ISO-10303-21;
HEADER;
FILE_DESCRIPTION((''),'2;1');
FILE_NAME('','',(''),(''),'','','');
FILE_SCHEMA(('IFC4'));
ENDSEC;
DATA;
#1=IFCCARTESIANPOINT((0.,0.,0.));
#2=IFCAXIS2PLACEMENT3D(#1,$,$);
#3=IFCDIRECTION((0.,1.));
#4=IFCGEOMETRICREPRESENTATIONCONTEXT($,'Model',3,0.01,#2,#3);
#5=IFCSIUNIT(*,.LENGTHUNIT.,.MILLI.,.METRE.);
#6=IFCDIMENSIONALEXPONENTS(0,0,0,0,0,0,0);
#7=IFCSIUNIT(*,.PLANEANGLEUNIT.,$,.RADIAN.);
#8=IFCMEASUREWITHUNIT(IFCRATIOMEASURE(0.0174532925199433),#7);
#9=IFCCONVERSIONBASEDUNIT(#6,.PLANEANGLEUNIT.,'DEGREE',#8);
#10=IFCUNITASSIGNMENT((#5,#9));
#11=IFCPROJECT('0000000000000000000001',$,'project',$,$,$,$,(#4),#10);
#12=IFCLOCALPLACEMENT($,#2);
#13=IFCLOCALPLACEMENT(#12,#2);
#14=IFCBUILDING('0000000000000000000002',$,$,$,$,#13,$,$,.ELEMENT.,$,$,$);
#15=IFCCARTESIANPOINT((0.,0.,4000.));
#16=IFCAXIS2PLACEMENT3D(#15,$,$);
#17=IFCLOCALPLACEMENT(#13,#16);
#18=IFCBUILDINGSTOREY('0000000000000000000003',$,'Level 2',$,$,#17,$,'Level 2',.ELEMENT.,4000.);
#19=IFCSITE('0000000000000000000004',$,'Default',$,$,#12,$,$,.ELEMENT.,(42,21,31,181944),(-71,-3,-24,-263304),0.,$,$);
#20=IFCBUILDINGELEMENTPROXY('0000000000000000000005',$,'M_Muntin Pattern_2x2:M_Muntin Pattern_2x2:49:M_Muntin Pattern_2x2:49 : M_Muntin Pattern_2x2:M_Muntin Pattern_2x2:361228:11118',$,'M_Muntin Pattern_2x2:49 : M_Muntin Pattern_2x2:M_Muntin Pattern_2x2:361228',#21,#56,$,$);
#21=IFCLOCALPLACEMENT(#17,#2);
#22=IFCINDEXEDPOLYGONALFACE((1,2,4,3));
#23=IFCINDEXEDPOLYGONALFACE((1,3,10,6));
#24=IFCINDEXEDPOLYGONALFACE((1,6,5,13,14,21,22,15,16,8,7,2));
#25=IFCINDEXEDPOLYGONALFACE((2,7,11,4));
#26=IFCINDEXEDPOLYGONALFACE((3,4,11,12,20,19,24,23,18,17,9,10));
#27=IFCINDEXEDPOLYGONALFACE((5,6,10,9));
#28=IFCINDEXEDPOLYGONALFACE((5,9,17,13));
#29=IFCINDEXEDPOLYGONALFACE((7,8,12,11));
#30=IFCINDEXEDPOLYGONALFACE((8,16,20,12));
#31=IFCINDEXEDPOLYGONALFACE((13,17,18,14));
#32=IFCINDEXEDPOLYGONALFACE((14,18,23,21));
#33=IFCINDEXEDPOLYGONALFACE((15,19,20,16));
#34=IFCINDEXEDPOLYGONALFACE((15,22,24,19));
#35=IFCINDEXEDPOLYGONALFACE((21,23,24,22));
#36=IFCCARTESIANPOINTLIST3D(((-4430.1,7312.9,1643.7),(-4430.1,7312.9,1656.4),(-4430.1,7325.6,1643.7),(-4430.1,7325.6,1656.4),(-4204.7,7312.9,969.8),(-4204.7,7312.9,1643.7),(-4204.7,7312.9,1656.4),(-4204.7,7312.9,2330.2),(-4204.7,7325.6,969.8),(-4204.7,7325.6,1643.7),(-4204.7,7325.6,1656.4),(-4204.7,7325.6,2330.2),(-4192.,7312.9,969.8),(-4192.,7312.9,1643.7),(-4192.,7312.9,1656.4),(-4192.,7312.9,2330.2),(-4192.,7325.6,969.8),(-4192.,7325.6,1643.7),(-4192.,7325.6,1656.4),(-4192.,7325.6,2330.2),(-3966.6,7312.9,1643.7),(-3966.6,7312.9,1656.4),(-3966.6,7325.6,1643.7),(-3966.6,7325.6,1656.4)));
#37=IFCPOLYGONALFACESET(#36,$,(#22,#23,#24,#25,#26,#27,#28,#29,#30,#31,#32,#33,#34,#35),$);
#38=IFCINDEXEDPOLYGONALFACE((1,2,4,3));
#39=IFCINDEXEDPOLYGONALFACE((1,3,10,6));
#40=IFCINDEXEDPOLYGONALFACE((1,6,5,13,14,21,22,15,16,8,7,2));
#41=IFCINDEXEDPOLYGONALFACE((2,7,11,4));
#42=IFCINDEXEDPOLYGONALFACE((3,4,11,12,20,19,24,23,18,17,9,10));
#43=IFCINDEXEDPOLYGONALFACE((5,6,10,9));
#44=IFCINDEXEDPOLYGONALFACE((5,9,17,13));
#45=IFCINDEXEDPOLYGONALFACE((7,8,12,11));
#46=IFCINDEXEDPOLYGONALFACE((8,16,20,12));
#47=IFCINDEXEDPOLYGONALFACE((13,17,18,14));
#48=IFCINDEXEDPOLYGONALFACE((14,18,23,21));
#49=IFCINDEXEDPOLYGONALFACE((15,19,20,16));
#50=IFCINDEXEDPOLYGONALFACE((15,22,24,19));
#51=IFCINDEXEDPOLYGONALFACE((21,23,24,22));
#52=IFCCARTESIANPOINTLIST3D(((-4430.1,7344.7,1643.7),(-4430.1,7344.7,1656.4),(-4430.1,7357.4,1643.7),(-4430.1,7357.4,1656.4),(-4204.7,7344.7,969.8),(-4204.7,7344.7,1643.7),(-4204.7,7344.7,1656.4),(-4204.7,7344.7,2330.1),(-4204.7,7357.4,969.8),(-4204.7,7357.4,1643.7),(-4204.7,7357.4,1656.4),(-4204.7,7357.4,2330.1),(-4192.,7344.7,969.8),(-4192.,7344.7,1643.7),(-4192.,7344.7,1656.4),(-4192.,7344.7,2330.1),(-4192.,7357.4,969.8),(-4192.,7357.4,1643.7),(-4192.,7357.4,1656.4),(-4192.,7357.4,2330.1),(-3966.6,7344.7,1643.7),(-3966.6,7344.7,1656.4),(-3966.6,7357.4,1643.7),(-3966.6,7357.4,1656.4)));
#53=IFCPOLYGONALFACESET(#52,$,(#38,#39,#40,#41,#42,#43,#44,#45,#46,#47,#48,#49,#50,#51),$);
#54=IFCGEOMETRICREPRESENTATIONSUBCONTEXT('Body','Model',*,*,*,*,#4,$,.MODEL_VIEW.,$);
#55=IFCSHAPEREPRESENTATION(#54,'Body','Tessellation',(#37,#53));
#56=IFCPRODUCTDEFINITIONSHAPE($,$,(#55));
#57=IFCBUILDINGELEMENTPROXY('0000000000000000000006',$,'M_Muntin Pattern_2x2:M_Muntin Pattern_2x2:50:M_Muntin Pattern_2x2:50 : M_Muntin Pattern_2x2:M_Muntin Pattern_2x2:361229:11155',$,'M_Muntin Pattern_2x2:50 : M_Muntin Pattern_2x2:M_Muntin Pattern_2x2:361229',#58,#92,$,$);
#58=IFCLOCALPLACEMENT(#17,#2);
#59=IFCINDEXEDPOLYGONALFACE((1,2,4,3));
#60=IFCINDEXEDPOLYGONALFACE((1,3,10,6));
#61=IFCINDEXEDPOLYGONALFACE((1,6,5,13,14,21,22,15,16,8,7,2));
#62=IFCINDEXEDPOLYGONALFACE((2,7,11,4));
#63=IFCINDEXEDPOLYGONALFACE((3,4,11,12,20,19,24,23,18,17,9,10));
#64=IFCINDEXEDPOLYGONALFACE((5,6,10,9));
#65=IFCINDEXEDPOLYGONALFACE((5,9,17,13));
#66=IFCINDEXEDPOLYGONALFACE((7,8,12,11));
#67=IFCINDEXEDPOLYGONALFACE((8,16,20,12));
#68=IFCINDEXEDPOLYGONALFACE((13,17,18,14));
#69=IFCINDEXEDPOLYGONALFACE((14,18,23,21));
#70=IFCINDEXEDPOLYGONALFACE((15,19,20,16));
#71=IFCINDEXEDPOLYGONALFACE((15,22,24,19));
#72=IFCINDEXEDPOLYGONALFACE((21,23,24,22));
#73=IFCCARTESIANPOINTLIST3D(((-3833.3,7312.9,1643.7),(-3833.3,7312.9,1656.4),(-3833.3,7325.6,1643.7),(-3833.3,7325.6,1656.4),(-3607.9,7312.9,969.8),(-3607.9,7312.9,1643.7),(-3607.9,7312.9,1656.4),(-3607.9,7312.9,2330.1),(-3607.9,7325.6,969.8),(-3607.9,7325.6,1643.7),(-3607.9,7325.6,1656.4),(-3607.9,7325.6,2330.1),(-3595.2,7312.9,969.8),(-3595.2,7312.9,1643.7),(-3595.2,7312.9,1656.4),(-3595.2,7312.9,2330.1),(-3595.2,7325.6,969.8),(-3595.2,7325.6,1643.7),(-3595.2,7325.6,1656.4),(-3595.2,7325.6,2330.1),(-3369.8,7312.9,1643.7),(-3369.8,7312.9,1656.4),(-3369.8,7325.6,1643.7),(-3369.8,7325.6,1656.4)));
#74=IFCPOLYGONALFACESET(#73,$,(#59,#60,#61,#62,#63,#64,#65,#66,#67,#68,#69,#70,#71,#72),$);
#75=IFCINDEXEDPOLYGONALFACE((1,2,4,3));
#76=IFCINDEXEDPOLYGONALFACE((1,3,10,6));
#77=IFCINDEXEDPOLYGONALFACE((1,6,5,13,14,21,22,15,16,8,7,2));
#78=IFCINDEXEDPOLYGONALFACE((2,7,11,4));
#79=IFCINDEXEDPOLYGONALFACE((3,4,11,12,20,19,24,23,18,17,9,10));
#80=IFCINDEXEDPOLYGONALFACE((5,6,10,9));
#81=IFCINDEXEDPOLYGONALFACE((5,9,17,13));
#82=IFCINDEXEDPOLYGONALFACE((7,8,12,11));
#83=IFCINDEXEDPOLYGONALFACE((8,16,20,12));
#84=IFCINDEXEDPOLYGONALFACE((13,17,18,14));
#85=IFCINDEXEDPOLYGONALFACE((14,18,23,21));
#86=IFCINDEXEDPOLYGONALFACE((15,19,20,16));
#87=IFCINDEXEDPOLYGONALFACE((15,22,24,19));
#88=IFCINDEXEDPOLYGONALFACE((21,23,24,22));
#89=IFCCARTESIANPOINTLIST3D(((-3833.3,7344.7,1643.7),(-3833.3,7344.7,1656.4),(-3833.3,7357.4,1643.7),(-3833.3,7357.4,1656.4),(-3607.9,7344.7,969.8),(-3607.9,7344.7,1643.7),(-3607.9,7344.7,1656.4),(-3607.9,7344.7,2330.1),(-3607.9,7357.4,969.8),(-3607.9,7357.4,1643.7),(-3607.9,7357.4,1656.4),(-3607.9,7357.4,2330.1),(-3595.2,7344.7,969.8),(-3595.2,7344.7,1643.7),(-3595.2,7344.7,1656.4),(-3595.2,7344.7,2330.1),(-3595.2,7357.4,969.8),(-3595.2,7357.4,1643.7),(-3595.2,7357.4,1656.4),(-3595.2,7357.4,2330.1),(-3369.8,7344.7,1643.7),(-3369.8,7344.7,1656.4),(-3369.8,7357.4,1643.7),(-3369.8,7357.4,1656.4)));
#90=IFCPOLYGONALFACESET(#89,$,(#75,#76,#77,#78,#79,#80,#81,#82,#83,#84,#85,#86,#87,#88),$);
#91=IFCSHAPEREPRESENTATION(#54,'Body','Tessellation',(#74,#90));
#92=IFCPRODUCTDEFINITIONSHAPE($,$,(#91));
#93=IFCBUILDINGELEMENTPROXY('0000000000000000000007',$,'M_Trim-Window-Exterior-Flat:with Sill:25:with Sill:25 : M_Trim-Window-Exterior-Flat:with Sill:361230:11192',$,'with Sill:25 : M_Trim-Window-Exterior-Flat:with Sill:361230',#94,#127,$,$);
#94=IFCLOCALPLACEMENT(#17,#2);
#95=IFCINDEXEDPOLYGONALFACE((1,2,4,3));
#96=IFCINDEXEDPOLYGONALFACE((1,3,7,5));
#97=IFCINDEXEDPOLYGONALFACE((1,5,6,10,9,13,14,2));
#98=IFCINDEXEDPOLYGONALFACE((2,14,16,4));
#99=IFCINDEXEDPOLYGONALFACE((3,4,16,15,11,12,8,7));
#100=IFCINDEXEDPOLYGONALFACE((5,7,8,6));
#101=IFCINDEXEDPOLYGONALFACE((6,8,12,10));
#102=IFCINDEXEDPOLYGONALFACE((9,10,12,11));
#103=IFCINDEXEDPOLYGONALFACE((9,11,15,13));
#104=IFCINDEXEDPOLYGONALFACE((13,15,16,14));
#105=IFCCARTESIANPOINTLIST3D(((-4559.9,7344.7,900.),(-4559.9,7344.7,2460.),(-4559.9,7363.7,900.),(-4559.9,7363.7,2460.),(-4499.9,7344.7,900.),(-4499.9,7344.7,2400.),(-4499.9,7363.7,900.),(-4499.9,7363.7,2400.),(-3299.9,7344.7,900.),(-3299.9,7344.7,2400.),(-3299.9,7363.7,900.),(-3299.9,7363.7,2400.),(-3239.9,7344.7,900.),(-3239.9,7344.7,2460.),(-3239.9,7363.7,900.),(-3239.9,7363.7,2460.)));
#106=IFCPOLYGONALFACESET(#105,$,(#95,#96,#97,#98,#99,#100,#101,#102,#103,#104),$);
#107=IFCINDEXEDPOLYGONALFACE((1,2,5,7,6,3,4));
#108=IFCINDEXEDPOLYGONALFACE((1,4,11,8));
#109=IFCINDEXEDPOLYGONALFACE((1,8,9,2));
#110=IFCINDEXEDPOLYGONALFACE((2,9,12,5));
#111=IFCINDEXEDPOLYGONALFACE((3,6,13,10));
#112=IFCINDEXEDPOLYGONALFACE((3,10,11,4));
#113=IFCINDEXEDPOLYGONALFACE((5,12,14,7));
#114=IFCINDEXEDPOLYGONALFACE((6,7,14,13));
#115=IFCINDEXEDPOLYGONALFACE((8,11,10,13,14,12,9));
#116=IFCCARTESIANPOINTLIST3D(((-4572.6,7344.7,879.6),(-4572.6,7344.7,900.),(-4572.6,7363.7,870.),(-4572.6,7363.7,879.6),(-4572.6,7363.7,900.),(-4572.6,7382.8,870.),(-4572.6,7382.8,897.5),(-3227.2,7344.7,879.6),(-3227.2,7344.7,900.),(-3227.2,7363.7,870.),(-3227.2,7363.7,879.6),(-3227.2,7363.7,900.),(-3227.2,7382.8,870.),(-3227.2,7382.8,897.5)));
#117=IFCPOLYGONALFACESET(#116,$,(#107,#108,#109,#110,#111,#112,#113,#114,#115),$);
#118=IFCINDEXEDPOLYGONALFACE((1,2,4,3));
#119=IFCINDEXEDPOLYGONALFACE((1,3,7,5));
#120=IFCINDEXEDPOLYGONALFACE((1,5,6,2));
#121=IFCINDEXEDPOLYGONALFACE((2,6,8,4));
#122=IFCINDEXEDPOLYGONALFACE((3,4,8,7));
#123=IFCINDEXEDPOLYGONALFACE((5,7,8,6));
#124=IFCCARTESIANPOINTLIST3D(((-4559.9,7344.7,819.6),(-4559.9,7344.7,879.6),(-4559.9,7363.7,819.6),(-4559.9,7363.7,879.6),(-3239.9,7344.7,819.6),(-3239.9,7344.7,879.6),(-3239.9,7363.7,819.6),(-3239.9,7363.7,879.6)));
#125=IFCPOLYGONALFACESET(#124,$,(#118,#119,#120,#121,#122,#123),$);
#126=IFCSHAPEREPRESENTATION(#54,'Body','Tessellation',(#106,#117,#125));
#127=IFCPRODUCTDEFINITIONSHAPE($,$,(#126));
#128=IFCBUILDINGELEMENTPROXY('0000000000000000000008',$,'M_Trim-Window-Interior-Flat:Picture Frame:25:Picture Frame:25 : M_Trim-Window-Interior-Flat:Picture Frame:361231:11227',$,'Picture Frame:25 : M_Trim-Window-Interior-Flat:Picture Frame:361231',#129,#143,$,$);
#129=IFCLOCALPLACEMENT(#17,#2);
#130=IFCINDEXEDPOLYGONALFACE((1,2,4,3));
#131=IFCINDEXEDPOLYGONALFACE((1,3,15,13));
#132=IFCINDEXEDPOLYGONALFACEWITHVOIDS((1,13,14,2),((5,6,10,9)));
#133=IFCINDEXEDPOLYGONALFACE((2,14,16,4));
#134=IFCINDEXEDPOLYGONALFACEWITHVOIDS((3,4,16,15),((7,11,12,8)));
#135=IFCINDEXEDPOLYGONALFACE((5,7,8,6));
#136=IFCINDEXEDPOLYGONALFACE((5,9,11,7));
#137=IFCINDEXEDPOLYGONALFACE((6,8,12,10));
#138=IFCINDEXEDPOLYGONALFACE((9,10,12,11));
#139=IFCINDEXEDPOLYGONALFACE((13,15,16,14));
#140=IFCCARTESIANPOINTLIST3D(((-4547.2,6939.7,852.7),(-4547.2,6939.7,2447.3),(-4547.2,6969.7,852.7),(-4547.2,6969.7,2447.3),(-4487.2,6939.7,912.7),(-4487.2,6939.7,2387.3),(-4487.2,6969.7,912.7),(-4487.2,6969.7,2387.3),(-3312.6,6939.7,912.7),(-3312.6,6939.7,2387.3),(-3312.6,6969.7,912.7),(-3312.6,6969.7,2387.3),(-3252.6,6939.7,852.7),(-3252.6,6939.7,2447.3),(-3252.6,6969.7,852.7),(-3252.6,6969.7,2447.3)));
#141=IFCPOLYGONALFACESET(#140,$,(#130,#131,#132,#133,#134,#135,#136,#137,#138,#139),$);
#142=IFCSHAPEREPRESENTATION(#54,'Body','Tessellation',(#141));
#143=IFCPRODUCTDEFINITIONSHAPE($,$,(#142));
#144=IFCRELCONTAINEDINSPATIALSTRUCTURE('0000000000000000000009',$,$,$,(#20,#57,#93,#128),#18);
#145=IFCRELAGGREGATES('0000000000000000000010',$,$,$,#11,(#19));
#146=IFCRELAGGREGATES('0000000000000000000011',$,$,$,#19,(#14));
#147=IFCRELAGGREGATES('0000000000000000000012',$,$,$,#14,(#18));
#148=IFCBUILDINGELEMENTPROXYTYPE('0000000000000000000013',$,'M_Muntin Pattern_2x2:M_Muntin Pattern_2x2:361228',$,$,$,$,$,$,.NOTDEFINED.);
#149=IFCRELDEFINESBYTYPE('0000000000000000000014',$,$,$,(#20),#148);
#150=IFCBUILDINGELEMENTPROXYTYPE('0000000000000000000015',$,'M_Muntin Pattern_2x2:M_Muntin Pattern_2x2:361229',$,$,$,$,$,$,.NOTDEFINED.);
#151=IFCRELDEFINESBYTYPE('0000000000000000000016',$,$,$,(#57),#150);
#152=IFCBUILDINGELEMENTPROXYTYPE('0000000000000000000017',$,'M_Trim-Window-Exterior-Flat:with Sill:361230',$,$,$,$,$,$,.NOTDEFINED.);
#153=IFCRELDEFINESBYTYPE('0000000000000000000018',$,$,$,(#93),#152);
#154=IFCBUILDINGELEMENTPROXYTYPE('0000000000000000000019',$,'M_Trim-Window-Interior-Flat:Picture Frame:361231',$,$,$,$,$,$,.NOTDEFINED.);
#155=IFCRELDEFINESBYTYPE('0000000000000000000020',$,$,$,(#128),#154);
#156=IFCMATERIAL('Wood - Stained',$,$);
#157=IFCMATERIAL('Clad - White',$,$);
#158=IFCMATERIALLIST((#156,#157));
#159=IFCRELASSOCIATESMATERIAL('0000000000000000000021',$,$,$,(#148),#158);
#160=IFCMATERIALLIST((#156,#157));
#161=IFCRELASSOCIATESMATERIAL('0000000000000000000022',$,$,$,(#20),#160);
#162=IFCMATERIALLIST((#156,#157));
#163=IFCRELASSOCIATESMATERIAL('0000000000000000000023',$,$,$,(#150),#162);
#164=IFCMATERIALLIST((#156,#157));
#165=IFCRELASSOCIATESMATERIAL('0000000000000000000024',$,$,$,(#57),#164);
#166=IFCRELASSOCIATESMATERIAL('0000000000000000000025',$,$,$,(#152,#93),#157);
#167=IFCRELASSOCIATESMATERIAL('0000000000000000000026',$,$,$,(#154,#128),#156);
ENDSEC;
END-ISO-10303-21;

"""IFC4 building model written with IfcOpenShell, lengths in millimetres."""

from ifc_helpers import new_model, entity, si_unit, converted_unit, direction, frame, origin, origin_2d_with_axis, place, context, subcontext, project, spatial, polyline, rectangle, outline, extrude, source, transform, mapped, material, material_list, type_object, type_shapes, element, save


model = new_model("IFC4")

# Units and contexts
model_context = context("Model", 3, precision=0.01, world=origin(), true_north=direction((0.0, 1.0)))
body_context = subcontext(model_context, "Body", "Model", "MODEL_VIEW")
ifc_project = project(units=[si_unit("LENGTHUNIT", "METRE", prefix="MILLI"), converted_unit("PLANEANGLEUNIT", "DEGREE", entity("IfcRatioMeasure", 0.0174532925199433), si_unit("PLANEANGLEUNIT", "RADIAN"), dimensions=[0, 0, 0, 0, 0, 0, 0])], contexts=[model_context])

# Site, building, storey
site_placement = place(None, origin())
site = spatial("IfcSite", under=ifc_project, at=site_placement, Name="Default", CompositionType="ELEMENT", RefLatitude=(42, 21, 31, 181944), RefLongitude=(-71, -3, -24, -263304), RefElevation=0.0)
building_placement = place(site_placement, origin())
building = spatial("IfcBuilding", under=site, at=building_placement, CompositionType="ELEMENT")
storey_placement = place(building_placement, frame((0.0, 0.0, 4000.0)))
storey = spatial("IfcBuildingStorey", under=building, at=storey_placement, Name="Level 2", LongName="Level 2", CompositionType="ELEMENT", Elevation=4000.0)

# Building element proxies
ifc_material_1 = material(Name="Wood - Stained")
ifc_material_2 = material(Name="Clad - White")
ifc_material_list_1 = material_list([ifc_material_1, ifc_material_2])
ifc_material_list_2 = material_list([ifc_material_1, ifc_material_2])
building_element_proxy_type_1 = type_object("IfcBuildingElementProxyType", Name="M_Muntin Pattern_2x2:M_Muntin Pattern_2x2:361228", PredefinedType="NOTDEFINED", material=ifc_material_list_2)
shared_shape_1 = source(origin(), body_context, "Body", "SweptSolid", [
    extrude(outline(polyline([(-6.4, -680.2), (6.3, -680.2), (6.3, -6.4), (231.7, -6.4), (231.7, 6.3), (6.3, 6.3), (6.3, 680.2), (-6.4, 680.2), (-6.4, 6.3), (-231.7, 6.3), (-231.7, -6.4), (-6.4, -6.4), (-6.4, -680.2)])), frame((-4198.4, 7312.9, 5650.0), z_axis=(0.0, 1.0, 0.0), x_axis=(1.0, 0.0, 0.0)), (0.0, 0.0, 1.0), 12.7),
    extrude(outline(polyline([(-6.4, -680.1), (6.3, -680.1), (6.3, -6.4), (231.7, -6.4), (231.7, 6.3), (6.3, 6.3), (6.3, 680.2), (-6.4, 680.2), (-6.4, 6.3), (-231.7, 6.3), (-231.7, -6.4), (-6.4, -6.4), (-6.4, -680.1)])), frame((-4198.4, 7344.7, 5650.0), z_axis=(0.0, 1.0, 0.0), x_axis=(1.0, 0.0, 0.0)), (0.0, 0.0, 1.0), 12.7),
])
type_shapes(building_element_proxy_type_1, [shared_shape_1])
proxy_1_placement = place(storey_placement, frame((0.0, 0.0, -4000.0)))
element("IfcBuildingElementProxy", 1, at=proxy_1_placement, inside=storey, type_object=building_element_proxy_type_1, material=ifc_material_list_1, Name="M_Muntin Pattern_2x2:M_Muntin Pattern_2x2:49:M_Muntin Pattern_2x2:49 : M_Muntin Pattern_2x2:M_Muntin Pattern_2x2:361228:11118", ObjectType="M_Muntin Pattern_2x2:49 : M_Muntin Pattern_2x2:M_Muntin Pattern_2x2:361228", context=body_context, shape_type="MappedRepresentation", body=[
    mapped(shared_shape_1, transform((0.0, 0.0, 0.0), scale=1.0)),
])
ifc_material_list_3 = material_list([ifc_material_1, ifc_material_2])
ifc_material_list_4 = material_list([ifc_material_1, ifc_material_2])
building_element_proxy_type_2 = type_object("IfcBuildingElementProxyType", Name="M_Muntin Pattern_2x2:M_Muntin Pattern_2x2:361229", PredefinedType="NOTDEFINED", material=ifc_material_list_4)
shared_shape_2 = source(origin(), body_context, "Body", "SweptSolid", [
    extrude(outline(polyline([(-680.1, 6.4), (-680.1, -6.3), (-6.4, -6.3), (-6.4, -231.7), (6.3, -231.7), (6.3, -6.3), (680.2, -6.3), (680.2, 6.4), (6.3, 6.4), (6.3, 231.7), (-6.4, 231.7), (-6.4, 6.4), (-680.1, 6.4)])), frame((-3601.5, 7312.9, 5650.0), z_axis=(0.0, -1.0, 0.0), x_axis=(0.0, 0.0, -1.0)), (0.0, 0.0, -1.0), 12.7),
    extrude(outline(polyline([(-680.1, 6.4), (-680.1, -6.3), (-6.4, -6.3), (-6.4, -231.7), (6.3, -231.7), (6.3, -6.3), (680.2, -6.3), (680.2, 6.4), (6.3, 6.4), (6.3, 231.7), (-6.4, 231.7), (-6.4, 6.4), (-680.1, 6.4)])), frame((-3601.5, 7344.7, 5650.0), z_axis=(0.0, -1.0, 0.0), x_axis=(0.0, 0.0, -1.0)), (0.0, 0.0, -1.0), 12.7),
])
type_shapes(building_element_proxy_type_2, [shared_shape_2])
proxy_2_placement = place(storey_placement, frame((0.0, 0.0, -4000.0)))
element("IfcBuildingElementProxy", 2, at=proxy_2_placement, inside=storey, type_object=building_element_proxy_type_2, material=ifc_material_list_3, Name="M_Muntin Pattern_2x2:M_Muntin Pattern_2x2:50:M_Muntin Pattern_2x2:50 : M_Muntin Pattern_2x2:M_Muntin Pattern_2x2:361229:11155", ObjectType="M_Muntin Pattern_2x2:50 : M_Muntin Pattern_2x2:M_Muntin Pattern_2x2:361229", context=body_context, shape_type="MappedRepresentation", body=[
    mapped(shared_shape_2, transform((0.0, 0.0, 0.0), scale=1.0)),
])
building_element_proxy_type_3 = type_object("IfcBuildingElementProxyType", Name="M_Trim-Window-Exterior-Flat:with Sill:361230", PredefinedType="NOTDEFINED", material=ifc_material_2)
shared_shape_3 = source(origin(), body_context, "Body", "SweptSolid", [
    extrude(outline(polyline([(-660.0, -765.0), (-600.0, -765.0), (-600.0, 735.0), (600.0, 735.0), (600.0, -765.0), (660.0, -765.0), (660.0, 795.0), (-660.0, 795.0), (-660.0, -765.0)])), frame((-3899.9, 7344.7, 5665.0), z_axis=(0.0, 1.0, 0.0), x_axis=(-1.0, 0.0, 0.0)), (0.0, 0.0, 1.0), 19.1),
    extrude(outline(polyline([(0.0, -15.2), (19.0, -15.2), (19.0, 12.3), (0.0, 14.8), (-19.0, 14.8), (-19.0, -5.7), (0.0, -5.7), (0.0, -15.2)])), frame((-4572.6, 7363.7, 4885.2), z_axis=(1.0, 0.0, 0.0), x_axis=(0.0, 1.0, 0.0)), (0.0, 0.0, 1.0), 1345.4),
    extrude(rectangle(XDim=19.1, YDim=1320.0, at=origin_2d_with_axis()), frame((-3899.9, 7354.2, 4819.6), z_axis=(0.0, 0.0, 1.0), x_axis=(0.0, -1.0, 0.0)), (0.0, 0.0, 1.0), 60.0),
])
type_shapes(building_element_proxy_type_3, [shared_shape_3])
proxy_3_placement = place(storey_placement, frame((0.0, 0.0, -4000.0)))
element("IfcBuildingElementProxy", 3, at=proxy_3_placement, inside=storey, type_object=building_element_proxy_type_3, material=ifc_material_2, Name="M_Trim-Window-Exterior-Flat:with Sill:25:with Sill:25 : M_Trim-Window-Exterior-Flat:with Sill:361230:11192", ObjectType="with Sill:25 : M_Trim-Window-Exterior-Flat:with Sill:361230", context=body_context, shape_type="MappedRepresentation", body=[
    mapped(shared_shape_3, transform((0.0, 0.0, 0.0), scale=1.0)),
])
building_element_proxy_type_4 = type_object("IfcBuildingElementProxyType", Name="M_Trim-Window-Interior-Flat:Picture Frame:361231", PredefinedType="NOTDEFINED", material=ifc_material_1)
shared_shape_4 = source(origin(), body_context, "Body", "SweptSolid", [
    extrude(outline(polyline([(-647.3, -797.3), (647.3, -797.3), (647.3, 797.3), (-647.3, 797.3), (-647.3, -797.3)]), holes=[polyline([(587.3, 737.3), (587.3, -737.3), (-587.3, -737.3), (-587.3, 737.3), (587.3, 737.3)])]), frame((-3899.9, 6939.7, 5650.0), z_axis=(0.0, 1.0, 0.0), x_axis=(1.0, 0.0, 0.0)), (0.0, 0.0, 1.0), 30.0),
])
type_shapes(building_element_proxy_type_4, [shared_shape_4])
proxy_4_placement = place(storey_placement, frame((0.0, 0.0, -4000.0)))
element("IfcBuildingElementProxy", 4, at=proxy_4_placement, inside=storey, type_object=building_element_proxy_type_4, material=ifc_material_1, Name="M_Trim-Window-Interior-Flat:Picture Frame:25:Picture Frame:25 : M_Trim-Window-Interior-Flat:Picture Frame:361231:11227", ObjectType="Picture Frame:25 : M_Trim-Window-Interior-Flat:Picture Frame:361231", context=body_context, shape_type="MappedRepresentation", body=[
    mapped(shared_shape_4, transform((0.0, 0.0, 0.0), scale=1.0)),
])

save(model, "model.ifc")
